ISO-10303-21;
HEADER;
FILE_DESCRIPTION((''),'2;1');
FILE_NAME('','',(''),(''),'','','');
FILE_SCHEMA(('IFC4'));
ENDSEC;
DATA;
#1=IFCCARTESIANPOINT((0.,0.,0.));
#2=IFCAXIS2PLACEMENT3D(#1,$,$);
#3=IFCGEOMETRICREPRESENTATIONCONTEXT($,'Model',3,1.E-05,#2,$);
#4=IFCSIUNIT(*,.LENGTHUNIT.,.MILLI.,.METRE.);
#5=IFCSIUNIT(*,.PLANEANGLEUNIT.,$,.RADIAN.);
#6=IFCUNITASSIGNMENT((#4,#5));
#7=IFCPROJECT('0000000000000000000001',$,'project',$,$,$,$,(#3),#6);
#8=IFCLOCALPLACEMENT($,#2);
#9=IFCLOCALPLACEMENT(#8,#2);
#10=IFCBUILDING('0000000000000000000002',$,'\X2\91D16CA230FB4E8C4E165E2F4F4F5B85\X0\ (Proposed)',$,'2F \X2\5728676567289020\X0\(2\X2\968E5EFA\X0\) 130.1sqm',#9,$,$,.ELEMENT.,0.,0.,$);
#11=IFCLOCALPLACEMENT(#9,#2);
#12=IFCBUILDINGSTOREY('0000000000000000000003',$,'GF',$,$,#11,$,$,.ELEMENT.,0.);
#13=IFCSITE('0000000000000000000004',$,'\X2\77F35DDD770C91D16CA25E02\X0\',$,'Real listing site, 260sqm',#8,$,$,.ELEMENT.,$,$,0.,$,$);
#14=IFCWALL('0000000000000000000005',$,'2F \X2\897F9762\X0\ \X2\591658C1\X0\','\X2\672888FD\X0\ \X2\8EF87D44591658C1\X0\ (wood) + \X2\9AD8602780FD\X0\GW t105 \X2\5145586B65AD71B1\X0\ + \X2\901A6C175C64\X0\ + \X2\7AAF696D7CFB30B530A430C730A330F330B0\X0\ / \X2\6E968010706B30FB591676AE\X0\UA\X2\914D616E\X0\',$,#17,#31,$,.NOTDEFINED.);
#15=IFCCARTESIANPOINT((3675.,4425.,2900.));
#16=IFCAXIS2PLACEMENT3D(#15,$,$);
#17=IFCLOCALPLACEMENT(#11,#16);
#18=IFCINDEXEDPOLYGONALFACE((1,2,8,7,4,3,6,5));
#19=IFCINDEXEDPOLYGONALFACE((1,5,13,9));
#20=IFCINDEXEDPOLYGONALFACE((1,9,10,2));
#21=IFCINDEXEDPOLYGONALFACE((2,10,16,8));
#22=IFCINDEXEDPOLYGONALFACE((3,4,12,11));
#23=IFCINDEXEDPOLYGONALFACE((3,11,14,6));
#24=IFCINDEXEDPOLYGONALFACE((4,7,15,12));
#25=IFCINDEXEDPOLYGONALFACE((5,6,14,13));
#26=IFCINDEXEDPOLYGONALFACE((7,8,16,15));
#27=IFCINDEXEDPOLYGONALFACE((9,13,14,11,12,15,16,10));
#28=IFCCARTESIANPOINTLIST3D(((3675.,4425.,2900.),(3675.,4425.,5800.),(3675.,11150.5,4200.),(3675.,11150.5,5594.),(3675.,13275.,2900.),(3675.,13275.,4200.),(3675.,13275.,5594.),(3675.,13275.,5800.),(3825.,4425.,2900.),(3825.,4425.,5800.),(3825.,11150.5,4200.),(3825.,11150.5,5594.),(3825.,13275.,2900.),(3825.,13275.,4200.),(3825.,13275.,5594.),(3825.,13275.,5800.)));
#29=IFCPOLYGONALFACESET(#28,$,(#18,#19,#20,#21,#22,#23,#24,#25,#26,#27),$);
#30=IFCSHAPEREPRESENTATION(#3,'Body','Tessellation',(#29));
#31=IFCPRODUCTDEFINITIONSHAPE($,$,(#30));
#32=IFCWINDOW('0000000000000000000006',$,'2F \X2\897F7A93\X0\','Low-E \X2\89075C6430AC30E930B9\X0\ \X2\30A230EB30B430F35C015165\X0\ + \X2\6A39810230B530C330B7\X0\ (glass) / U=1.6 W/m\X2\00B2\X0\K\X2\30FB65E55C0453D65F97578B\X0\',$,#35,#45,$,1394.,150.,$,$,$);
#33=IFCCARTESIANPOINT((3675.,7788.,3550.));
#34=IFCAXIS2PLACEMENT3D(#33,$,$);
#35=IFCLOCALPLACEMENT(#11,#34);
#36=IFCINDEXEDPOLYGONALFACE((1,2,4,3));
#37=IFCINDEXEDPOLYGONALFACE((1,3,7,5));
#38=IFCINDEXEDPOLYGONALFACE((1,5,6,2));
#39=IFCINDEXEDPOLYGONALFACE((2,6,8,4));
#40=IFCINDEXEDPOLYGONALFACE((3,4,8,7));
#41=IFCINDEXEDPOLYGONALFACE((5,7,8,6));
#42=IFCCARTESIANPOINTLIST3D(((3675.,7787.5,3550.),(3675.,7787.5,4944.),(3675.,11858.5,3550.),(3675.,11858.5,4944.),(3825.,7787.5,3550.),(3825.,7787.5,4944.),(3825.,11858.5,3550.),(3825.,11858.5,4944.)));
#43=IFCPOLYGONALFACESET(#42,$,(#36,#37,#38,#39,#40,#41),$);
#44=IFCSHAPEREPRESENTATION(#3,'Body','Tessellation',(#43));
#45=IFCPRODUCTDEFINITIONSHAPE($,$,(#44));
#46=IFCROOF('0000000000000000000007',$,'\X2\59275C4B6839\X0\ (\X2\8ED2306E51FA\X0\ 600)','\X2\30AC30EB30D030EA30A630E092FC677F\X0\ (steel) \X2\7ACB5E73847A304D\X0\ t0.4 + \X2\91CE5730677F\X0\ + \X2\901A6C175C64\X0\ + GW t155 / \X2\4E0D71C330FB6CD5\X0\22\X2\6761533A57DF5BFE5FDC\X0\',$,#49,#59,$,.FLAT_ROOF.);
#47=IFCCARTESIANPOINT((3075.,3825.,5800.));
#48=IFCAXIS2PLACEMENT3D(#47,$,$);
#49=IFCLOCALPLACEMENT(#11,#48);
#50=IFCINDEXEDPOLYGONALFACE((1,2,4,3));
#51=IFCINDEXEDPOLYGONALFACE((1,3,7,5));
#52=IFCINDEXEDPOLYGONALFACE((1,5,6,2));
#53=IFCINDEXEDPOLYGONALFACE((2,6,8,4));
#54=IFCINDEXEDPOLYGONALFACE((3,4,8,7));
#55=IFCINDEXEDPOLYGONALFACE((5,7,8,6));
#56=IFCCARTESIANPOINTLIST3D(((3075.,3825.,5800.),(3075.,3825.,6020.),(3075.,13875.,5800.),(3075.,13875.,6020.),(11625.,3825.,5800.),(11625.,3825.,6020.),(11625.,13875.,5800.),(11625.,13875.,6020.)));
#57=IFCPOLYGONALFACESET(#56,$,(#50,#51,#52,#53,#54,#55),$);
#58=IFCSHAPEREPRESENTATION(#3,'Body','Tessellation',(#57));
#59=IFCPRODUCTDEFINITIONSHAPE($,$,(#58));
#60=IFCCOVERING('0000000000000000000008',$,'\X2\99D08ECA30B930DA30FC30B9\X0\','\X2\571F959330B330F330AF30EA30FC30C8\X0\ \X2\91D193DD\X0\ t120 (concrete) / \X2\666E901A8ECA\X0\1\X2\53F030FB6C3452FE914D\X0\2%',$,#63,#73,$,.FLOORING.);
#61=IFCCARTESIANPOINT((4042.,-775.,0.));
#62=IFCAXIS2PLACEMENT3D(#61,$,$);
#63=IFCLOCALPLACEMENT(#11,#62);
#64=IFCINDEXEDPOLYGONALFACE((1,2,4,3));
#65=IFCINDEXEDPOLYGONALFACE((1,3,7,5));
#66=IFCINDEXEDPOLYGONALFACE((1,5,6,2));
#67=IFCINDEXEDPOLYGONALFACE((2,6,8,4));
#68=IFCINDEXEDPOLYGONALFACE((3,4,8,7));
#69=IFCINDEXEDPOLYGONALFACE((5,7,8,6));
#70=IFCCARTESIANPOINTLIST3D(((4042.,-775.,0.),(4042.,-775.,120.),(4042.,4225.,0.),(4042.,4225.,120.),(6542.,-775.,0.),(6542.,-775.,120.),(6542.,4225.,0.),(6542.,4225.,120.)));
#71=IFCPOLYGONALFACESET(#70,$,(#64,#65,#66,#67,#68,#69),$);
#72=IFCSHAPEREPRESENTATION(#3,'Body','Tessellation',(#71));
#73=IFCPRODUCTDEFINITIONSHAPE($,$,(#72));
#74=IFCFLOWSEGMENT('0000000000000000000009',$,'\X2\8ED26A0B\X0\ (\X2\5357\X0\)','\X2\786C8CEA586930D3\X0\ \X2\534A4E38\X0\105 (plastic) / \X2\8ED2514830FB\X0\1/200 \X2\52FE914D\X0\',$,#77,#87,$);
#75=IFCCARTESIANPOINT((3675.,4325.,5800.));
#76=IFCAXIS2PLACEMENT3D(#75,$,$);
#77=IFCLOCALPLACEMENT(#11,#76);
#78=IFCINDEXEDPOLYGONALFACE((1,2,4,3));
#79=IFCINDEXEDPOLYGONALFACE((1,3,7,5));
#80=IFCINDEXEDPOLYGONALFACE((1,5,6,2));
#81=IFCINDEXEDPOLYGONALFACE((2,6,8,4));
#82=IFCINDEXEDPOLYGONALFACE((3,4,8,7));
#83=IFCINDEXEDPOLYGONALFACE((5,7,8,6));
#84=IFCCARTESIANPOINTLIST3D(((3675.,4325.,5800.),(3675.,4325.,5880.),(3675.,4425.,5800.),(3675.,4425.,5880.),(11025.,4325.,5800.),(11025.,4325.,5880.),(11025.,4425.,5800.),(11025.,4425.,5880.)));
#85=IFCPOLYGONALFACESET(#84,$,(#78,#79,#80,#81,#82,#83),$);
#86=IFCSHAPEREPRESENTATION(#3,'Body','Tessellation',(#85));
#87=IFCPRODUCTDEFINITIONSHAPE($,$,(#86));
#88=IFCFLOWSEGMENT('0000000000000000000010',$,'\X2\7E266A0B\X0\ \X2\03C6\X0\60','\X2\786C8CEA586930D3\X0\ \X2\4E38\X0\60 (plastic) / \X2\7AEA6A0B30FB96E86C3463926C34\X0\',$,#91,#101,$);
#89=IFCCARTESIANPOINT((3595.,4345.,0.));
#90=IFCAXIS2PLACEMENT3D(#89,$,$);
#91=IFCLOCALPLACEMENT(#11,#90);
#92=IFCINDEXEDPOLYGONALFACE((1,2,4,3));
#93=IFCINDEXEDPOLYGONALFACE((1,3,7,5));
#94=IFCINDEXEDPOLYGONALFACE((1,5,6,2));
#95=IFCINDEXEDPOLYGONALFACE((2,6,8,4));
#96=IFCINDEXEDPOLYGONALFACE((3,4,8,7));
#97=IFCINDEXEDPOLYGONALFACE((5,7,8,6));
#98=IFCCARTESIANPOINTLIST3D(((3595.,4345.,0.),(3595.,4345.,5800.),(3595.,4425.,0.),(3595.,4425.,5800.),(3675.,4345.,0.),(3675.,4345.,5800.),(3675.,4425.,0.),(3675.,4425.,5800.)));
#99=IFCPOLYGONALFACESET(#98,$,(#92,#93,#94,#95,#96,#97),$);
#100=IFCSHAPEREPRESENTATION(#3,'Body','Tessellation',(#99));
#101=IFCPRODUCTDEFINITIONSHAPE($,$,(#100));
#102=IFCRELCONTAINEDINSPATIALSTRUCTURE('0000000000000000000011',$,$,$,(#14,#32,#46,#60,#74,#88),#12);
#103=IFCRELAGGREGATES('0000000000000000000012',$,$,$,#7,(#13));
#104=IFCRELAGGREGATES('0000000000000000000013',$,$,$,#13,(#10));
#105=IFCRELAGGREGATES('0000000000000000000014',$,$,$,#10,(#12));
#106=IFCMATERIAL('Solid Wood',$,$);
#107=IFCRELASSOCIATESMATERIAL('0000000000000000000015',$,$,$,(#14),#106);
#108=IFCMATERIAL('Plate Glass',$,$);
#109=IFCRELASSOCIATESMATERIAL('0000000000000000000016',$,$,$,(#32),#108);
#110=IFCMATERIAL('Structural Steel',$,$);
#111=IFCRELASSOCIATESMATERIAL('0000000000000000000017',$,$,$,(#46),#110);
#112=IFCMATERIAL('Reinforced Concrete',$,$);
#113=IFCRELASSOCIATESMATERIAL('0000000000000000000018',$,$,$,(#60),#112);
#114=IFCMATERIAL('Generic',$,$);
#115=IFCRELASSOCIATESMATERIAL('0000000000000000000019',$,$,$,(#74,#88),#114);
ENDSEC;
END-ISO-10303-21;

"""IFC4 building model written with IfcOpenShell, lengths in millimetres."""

from ifc_helpers import new_model, si_unit, frame, frame_2d, origin, place, context, project, spatial, rectangle, extrude, material, element, fill, save


model = new_model("IFC4")

# Units and contexts
model_context = context("Model", 3, precision=1e-05, world=origin())
ifc_project = project(units=[si_unit("LENGTHUNIT", "METRE", prefix="MILLI"), si_unit("PLANEANGLEUNIT", "RADIAN")], contexts=[model_context])

# Site, building, storey
site_placement = place(None, origin())
site = spatial("IfcSite", under=ifc_project, at=site_placement, Name="石川県金沢市", ObjectType="Real listing site, 260sqm", CompositionType="ELEMENT", RefElevation=0.0)
building_placement = place(site_placement, origin())
building = spatial("IfcBuilding", under=site, at=building_placement, Name="金沢・二世帯住宅 (Proposed)", ObjectType="2F 在来木造(2階建) 130.1sqm", CompositionType="ELEMENT", ElevationOfRefHeight=0.0, ElevationOfTerrain=0.0)
storey_placement = place(building_placement, origin())
storey = spatial("IfcBuildingStorey", under=building, at=storey_placement, Name="GF", CompositionType="ELEMENT", Elevation=0.0)

# Shared definitions
ifc_material_1 = material(Name="Solid Wood")

# Shared definitions
ifc_material_2 = material(Name="Reinforced Concrete")

# Shared definitions
ifc_material_3 = material(Name="Plate Glass")

# Wall, opening, window
wall_1_placement = place(storey_placement, frame((3675.0, 4425.0, 2900.0)))
wall_1 = element("IfcWall", 1, at=wall_1_placement, inside=storey, material=ifc_material_1, Name="2F 西面 外壁", Description="木製 軸組外壁 (wood) + 高性能GW t105 充填断熱 + 通気層 + 窯業系サイディング / 準耐火・外皮UA配慮", PredefinedType="NOTDEFINED", context=model_context, shape_type="SweptSolid", body=[
    extrude(rectangle(XDim=150.0, YDim=8850.0, at=frame_2d((75.0, 4425.0))), frame((3675.0, 4425.0, 2900.0)), (0.0, 0.0, 1.0), 2900.0),
])
opening_1_placement = place(storey_placement, frame((3675.0, 7788.0, 3550.0)))
opening_1 = element("IfcOpeningElement", 2, at=opening_1_placement, cuts=wall_1, PredefinedType="NOTDEFINED", context=model_context, shape_type="SweptSolid", body=[
    extrude(rectangle(XDim=150.0, YDim=4071.0, at=frame_2d((75.0, 2035.0))), frame((3675.0, 7788.0, 3550.0)), (0.0, 0.0, 1.0), 1394.0),
])
window_1_placement = place(storey_placement, frame((3675.0, 7788.0, 3550.0)))
window_1 = element("IfcWindow", 3, at=window_1_placement, inside=storey, material=ifc_material_3, Name="2F 西窓", Description="Low-E 複層ガラス アルゴン封入 + 樹脂サッシ (glass) / U=1.6 W/m²K・日射取得型", OverallHeight=1394.0, OverallWidth=150.0, context=model_context, shape_type="SweptSolid", body=[
    extrude(rectangle(XDim=150.0, YDim=4071.0, at=frame_2d((75.0, 2035.0))), frame((3675.0, 7788.0, 3550.0)), (0.0, 0.0, 1.0), 1394.0),
])
fill(opening_1, window_1)

# Roof
ifc_material_4 = material(Name="Structural Steel")
roof_placement = place(storey_placement, frame((3075.0, 3825.0, 5800.0)))
element("IfcRoof", 4, at=roof_placement, inside=storey, material=ifc_material_4, Name="大屋根 (軒の出 600)", Description="ガルバリウム鋼板 (steel) 立平葺き t0.4 + 野地板 + 通気層 + GW t155 / 不燃・法22条区域対応", PredefinedType="FLAT_ROOF", context=model_context, shape_type="SweptSolid", body=[
    extrude(rectangle(XDim=8550.0, YDim=10050.0, at=frame_2d((4275.0, 5025.0))), frame((3075.0, 3825.0, 5800.0)), (0.0, 0.0, 1.0), 220.0),
])

# Covering
covering_placement = place(storey_placement, frame((4042.0, -775.0, 0.0)))
element("IfcCovering", 5, at=covering_placement, inside=storey, material=ifc_material_2, Name="駐車スペース", Description="土間コンクリート 金鏝 t120 (concrete) / 普通車1台・水勾配2%", PredefinedType="FLOORING", context=model_context, shape_type="SweptSolid", body=[
    extrude(rectangle(XDim=2500.0, YDim=5000.0, at=frame_2d((1250.0, 2500.0))), frame((4042.0, -775.0, 0.0)), (0.0, 0.0, 1.0), 120.0),
])

# Flow segments
ifc_material_5 = material(Name="Generic")
flow_segment_1_placement = place(storey_placement, frame((3675.0, 4325.0, 5800.0)))
element("IfcFlowSegment", 6, at=flow_segment_1_placement, inside=storey, material=ifc_material_5, Name="軒樋 (南)", Description="硬質塩ビ 半丸105 (plastic) / 軒先・1/200 勾配", context=model_context, shape_type="SweptSolid", body=[
    extrude(rectangle(XDim=7350.0, YDim=100.0, at=frame_2d((3675.0, 50.0))), frame((3675.0, 4325.0, 5800.0)), (0.0, 0.0, 1.0), 80.0),
])
flow_segment_2_placement = place(storey_placement, frame((3595.0, 4345.0, 0.0)))
element("IfcFlowSegment", 7, at=flow_segment_2_placement, inside=storey, material=ifc_material_5, Name="縦樋 φ60", Description="硬質塩ビ 丸60 (plastic) / 竪樋・雨水排水", context=model_context, shape_type="SweptSolid", body=[
    extrude(rectangle(XDim=80.0, YDim=80.0, at=frame_2d((40.0, 40.0))), frame((3595.0, 4345.0, 0.0)), (0.0, 0.0, 1.0), 5800.0),
])

save(model, "model.ifc")
